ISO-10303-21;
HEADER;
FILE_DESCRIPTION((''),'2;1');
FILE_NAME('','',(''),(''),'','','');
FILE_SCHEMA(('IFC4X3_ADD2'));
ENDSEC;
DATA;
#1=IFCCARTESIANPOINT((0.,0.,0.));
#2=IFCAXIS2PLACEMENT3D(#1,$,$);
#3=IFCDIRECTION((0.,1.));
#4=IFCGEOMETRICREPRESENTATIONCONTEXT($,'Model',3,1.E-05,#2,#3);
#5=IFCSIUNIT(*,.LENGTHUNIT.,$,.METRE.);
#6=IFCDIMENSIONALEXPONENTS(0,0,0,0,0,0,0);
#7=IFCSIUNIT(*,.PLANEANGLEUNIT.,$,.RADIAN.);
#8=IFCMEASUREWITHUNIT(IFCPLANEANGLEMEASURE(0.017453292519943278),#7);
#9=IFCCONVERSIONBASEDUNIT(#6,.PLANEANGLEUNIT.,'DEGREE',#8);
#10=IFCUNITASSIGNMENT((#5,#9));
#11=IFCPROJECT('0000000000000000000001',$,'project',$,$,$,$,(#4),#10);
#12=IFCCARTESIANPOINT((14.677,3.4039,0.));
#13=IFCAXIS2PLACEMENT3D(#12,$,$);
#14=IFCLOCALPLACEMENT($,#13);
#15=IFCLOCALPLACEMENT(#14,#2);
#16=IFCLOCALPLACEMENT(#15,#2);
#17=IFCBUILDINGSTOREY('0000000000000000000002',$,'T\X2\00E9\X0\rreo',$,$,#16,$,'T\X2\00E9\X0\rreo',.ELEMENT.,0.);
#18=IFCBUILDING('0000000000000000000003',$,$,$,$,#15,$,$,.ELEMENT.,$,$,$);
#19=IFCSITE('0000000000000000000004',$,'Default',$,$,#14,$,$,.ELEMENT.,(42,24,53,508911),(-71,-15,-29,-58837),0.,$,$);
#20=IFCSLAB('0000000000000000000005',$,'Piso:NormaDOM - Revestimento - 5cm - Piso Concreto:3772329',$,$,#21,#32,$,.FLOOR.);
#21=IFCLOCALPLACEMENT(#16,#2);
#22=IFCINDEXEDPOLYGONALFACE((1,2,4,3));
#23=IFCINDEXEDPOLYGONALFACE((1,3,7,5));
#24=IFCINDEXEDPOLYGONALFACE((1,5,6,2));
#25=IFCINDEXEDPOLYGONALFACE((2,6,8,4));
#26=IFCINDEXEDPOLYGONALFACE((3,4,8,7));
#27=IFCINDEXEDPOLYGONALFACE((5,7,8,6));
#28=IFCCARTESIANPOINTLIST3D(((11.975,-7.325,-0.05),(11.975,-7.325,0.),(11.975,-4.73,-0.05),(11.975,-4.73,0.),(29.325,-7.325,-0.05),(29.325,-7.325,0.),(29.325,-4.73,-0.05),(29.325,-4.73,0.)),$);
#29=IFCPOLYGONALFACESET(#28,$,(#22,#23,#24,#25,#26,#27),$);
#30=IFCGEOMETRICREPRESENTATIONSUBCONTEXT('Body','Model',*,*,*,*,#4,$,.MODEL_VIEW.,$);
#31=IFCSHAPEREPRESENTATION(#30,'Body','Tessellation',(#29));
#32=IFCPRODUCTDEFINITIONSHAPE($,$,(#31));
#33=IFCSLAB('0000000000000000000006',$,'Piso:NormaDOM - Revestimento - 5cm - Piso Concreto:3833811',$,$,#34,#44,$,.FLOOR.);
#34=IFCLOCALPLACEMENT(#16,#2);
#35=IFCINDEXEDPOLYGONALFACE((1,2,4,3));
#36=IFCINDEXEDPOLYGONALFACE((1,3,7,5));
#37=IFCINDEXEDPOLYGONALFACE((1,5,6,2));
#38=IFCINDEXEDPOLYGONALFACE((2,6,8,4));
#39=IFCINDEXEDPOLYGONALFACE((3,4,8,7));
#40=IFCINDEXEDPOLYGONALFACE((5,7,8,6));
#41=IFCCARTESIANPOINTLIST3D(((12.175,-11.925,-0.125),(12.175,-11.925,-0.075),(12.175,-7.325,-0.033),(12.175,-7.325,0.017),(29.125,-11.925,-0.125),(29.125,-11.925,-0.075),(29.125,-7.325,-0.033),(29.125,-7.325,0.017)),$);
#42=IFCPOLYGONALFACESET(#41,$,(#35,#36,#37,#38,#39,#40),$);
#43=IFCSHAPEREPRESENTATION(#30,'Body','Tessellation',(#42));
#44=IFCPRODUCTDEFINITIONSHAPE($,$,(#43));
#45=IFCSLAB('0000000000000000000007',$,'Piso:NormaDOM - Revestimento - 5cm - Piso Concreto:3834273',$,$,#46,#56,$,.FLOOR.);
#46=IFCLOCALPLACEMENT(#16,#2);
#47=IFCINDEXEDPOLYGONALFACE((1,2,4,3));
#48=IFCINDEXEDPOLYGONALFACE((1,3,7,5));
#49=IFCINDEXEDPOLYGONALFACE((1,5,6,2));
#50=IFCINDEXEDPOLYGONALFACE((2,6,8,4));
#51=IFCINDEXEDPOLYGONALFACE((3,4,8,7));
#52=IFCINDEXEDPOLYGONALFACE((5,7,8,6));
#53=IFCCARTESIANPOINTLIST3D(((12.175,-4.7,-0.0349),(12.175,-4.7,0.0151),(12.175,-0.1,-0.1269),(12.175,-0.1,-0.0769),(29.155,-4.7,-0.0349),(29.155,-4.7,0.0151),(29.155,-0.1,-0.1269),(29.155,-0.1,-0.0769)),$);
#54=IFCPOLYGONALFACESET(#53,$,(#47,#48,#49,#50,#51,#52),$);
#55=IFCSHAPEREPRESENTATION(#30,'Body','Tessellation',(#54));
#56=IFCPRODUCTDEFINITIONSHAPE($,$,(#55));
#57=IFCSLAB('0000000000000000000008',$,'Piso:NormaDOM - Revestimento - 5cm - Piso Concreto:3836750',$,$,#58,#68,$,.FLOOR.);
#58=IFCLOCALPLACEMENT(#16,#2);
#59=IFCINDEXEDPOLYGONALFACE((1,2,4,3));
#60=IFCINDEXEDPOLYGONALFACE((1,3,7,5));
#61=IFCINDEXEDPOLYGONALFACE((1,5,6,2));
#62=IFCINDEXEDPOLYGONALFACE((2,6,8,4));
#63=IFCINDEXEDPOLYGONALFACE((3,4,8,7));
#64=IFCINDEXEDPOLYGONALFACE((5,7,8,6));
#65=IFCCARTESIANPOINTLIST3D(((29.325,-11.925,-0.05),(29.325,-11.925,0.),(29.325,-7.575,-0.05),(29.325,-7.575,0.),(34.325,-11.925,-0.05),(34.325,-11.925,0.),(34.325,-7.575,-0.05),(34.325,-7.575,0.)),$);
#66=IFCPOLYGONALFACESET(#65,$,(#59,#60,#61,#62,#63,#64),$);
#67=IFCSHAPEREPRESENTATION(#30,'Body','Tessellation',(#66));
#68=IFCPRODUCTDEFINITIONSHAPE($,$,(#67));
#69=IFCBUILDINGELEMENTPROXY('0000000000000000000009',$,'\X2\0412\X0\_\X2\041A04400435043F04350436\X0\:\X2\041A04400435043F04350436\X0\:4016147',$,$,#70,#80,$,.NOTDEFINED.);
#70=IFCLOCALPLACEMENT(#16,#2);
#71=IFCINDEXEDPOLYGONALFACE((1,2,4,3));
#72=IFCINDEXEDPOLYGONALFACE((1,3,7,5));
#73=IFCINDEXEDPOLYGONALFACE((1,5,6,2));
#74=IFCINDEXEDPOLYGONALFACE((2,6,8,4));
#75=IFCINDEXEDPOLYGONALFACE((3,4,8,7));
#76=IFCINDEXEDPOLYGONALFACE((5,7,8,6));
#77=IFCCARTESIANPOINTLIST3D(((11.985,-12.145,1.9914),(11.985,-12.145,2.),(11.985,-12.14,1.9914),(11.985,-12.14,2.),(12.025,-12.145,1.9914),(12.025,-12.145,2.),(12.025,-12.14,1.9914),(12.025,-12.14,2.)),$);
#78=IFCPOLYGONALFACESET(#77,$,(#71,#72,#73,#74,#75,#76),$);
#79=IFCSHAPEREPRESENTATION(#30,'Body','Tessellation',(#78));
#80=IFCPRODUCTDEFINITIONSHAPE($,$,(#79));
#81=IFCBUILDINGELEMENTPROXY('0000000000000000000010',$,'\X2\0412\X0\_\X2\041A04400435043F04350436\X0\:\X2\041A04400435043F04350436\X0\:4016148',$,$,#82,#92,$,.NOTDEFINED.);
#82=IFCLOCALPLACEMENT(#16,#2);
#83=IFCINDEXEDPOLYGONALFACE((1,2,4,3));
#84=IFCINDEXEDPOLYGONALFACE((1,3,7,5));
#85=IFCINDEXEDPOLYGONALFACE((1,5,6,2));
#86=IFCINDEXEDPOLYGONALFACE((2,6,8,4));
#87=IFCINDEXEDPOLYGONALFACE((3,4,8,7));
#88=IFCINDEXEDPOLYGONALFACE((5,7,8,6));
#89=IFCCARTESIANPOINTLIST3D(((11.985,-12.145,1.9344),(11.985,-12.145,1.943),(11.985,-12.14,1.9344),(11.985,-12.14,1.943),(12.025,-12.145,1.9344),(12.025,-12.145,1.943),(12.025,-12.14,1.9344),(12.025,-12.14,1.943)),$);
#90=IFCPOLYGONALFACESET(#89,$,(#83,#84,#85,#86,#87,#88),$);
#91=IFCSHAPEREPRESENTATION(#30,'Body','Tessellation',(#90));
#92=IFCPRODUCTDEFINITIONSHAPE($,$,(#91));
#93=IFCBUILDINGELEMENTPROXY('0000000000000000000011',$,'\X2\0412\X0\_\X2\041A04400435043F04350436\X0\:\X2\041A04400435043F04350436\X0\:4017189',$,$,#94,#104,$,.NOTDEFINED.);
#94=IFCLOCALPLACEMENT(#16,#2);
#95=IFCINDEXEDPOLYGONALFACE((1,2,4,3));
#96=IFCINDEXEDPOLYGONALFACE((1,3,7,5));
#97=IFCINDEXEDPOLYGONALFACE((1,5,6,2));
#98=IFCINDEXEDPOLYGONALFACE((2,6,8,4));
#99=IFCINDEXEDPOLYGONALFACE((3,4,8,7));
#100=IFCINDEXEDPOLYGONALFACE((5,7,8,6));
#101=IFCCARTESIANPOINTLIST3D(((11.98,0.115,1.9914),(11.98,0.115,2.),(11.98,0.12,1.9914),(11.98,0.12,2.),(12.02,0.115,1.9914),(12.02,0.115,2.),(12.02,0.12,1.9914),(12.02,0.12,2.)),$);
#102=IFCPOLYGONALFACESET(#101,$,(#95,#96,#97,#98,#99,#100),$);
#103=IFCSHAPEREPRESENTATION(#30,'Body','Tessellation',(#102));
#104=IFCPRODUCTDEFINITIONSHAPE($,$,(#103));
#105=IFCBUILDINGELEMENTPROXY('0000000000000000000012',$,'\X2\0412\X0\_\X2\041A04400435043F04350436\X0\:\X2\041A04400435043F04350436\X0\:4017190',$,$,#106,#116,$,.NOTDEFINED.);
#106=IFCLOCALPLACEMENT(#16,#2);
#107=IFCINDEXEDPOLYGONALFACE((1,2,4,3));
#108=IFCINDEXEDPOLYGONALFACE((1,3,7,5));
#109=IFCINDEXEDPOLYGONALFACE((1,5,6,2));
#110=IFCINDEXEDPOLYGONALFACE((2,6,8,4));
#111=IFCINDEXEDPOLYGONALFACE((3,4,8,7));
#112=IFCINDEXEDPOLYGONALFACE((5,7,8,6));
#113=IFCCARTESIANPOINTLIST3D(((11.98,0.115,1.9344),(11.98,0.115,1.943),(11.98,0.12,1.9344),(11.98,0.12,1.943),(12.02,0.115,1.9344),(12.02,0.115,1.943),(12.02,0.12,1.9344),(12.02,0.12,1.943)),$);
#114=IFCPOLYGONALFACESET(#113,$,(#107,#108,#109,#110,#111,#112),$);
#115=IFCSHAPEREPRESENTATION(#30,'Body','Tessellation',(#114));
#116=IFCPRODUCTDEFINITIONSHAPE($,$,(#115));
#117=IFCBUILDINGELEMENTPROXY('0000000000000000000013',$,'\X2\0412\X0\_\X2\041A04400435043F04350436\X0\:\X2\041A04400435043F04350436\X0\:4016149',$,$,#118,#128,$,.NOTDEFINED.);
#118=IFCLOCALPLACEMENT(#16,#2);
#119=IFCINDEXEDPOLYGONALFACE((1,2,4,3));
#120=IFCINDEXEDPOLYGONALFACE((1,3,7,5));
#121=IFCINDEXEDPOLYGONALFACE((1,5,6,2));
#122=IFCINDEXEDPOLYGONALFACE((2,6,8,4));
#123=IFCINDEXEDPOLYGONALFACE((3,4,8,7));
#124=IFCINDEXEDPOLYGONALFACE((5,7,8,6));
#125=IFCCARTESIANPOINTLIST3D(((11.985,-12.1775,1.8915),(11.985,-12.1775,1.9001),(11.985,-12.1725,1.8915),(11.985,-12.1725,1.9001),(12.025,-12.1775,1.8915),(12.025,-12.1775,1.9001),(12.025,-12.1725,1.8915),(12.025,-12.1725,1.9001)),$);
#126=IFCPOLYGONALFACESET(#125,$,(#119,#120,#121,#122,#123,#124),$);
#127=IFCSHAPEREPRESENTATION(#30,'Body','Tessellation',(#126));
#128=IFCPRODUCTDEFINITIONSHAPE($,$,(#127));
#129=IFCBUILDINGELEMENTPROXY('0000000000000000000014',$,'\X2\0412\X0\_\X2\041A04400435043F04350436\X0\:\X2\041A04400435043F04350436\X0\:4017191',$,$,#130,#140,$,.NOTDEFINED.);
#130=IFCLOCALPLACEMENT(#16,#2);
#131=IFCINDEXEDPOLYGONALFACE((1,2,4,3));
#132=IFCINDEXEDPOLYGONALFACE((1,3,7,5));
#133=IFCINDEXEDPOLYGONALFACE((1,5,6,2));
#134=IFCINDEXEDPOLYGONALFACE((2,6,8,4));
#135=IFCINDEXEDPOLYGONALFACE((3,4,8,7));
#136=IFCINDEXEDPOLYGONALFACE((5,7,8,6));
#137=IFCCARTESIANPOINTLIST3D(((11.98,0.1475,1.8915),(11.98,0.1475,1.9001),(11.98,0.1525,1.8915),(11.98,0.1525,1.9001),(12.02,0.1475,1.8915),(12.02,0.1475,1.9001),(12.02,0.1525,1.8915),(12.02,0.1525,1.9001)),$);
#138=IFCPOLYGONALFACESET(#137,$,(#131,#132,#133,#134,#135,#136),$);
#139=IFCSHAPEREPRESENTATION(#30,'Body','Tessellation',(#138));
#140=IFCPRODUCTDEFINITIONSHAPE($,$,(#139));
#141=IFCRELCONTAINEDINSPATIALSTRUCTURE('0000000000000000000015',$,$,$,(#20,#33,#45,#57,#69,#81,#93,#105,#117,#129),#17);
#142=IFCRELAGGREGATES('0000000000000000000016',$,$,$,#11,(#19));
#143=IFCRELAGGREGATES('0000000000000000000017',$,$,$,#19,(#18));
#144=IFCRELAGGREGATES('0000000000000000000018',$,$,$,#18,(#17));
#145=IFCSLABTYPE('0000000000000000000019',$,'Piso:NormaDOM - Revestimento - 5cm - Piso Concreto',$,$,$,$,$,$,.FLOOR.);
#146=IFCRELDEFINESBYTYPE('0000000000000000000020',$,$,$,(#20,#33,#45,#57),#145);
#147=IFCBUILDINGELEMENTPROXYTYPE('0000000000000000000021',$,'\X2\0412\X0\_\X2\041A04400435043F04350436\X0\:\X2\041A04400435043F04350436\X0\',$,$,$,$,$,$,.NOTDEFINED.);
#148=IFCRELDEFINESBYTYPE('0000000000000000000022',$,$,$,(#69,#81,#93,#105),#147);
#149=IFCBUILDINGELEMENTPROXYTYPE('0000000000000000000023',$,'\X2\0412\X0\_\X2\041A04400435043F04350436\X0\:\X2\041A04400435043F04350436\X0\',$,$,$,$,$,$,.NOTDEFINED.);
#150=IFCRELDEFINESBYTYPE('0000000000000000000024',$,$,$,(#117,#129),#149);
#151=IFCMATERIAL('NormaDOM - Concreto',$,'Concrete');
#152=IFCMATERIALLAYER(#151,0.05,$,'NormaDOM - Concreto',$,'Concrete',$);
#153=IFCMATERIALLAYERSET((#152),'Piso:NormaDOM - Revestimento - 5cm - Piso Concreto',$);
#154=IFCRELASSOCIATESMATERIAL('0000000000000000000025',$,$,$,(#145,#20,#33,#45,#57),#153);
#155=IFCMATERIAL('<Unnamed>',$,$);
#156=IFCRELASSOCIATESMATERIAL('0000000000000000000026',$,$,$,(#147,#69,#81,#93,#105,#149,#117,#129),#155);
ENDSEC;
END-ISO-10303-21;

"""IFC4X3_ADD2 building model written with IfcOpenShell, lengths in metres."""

from ifc_helpers import new_model, entity, si_unit, converted_unit, direction, frame, frame_2d, origin, origin_2d_with_axis, place, context, subcontext, project, spatial, rectangle, extrude, clip, halfspace, source, transform, mapped, material, layer, layer_set, layer_usage, type_object, type_shapes, element, save


model = new_model("IFC4X3_ADD2")

# Units and contexts
model_context = context("Model", 3, precision=1e-05, world=origin(), true_north=direction((0.0, 1.0)))
body_context = subcontext(model_context, "Body", "Model", "MODEL_VIEW")
ifc_project = project(units=[si_unit("LENGTHUNIT", "METRE"), converted_unit("PLANEANGLEUNIT", "DEGREE", entity("IfcPlaneAngleMeasure", 0.017453292519943278), si_unit("PLANEANGLEUNIT", "RADIAN"), dimensions=[0, 0, 0, 0, 0, 0, 0])], contexts=[model_context])

# Site, building, storey
site_placement = place(None, frame((14.677, 3.4039, 0.0)))
site = spatial("IfcSite", under=ifc_project, at=site_placement, Name="Default", CompositionType="ELEMENT", RefLatitude=(42, 24, 53, 508911), RefLongitude=(-71, -15, -29, -58837), RefElevation=0.0)
building_placement = place(site_placement, origin())
building = spatial("IfcBuilding", under=site, at=building_placement, CompositionType="ELEMENT")
storey_placement = place(building_placement, origin())
storey = spatial("IfcBuildingStorey", under=building, at=storey_placement, Name="Térreo", LongName="Térreo", CompositionType="ELEMENT", Elevation=0.0)

# Slabs
ifc_material_1 = material(Name="NormaDOM - Concreto", Category="Concrete")
ifc_layer_1 = layer(ifc_material_1, 0.05, Name="NormaDOM - Concreto", Category="Concrete")
ifc_layer_set_1 = layer_set([ifc_layer_1], Name="Piso:NormaDOM - Revestimento - 5cm - Piso Concreto")
ifc_layer_usage_1 = layer_usage(ifc_layer_set_1, "AXIS3", "POSITIVE", 0.0)
slab_type_1 = type_object("IfcSlabType", Name="Piso:NormaDOM - Revestimento - 5cm - Piso Concreto", PredefinedType="FLOOR", material=ifc_layer_set_1)
slab_1_placement = place(storey_placement, origin())
element("IfcSlab", 1, at=slab_1_placement, inside=storey, type_object=slab_type_1, material=ifc_layer_usage_1, Name="Piso:NormaDOM - Revestimento - 5cm - Piso Concreto:3772329", PredefinedType="FLOOR", context=body_context, shape_type="SweptSolid", body=[
    extrude(rectangle(XDim=2.595, YDim=17.35, at=frame_2d((0.0, 0.0), x_axis=(1.0, 0.0))), frame((20.65, -6.0275, 0.0), z_axis=(0.0, 0.0, -1.0), x_axis=(0.0, 1.0, 0.0)), (0.0, 0.0, 1.0), 0.05),
])
ifc_layer_usage_2 = layer_usage(ifc_layer_set_1, "AXIS3", "POSITIVE", 0.0)
slab_2_placement = place(storey_placement, origin())
element("IfcSlab", 2, at=slab_2_placement, inside=storey, type_object=slab_type_1, material=ifc_layer_usage_2, Name="Piso:NormaDOM - Revestimento - 5cm - Piso Concreto:3833811", PredefinedType="FLOOR", context=body_context, shape_type="Clipping", body=[
    clip(clip(extrude(rectangle(XDim=4.6009, YDim=16.95, at=frame_2d((0.0, 0.0), x_axis=(1.0, 0.0))), frame((20.65, -9.625, -0.029), z_axis=(0.0, 0.019996, -0.9998), x_axis=(0.0, 0.9998, 0.019996)), (-0.019996, 0.0, 0.9998), 0.05), halfspace(frame((20.8903, -8.1737, -0.05), z_axis=(0.0, 0.019996, -0.9998), x_axis=(0.0, -0.9998, -0.019996)), False)), halfspace(frame((20.8903, -8.1737, 0.0), z_axis=(0.0, -0.019996, 0.9998), x_axis=(0.0, 0.9998, 0.019996)), False)),
])
ifc_layer_usage_3 = layer_usage(ifc_layer_set_1, "AXIS3", "POSITIVE", 0.0)
slab_3_placement = place(storey_placement, origin())
element("IfcSlab", 3, at=slab_3_placement, inside=storey, type_object=slab_type_1, material=ifc_layer_usage_3, Name="Piso:NormaDOM - Revestimento - 5cm - Piso Concreto:3834273", PredefinedType="FLOOR", context=body_context, shape_type="Clipping", body=[
    clip(clip(extrude(rectangle(XDim=4.6009, YDim=16.98, at=origin_2d_with_axis()), frame((20.665, -2.4, -0.0309), z_axis=(0.0, -0.019996, -0.9998), x_axis=(0.0, 0.9998, -0.019996)), (0.019996, 0.0, 0.9998), 0.05), halfspace(frame((20.7124, -3.9462, -0.05), z_axis=(0.0, -0.019996, -0.9998), x_axis=(0.0, 0.9998, -0.019996)), False)), halfspace(frame((20.7124, -3.9462, 0.0), z_axis=(0.0, 0.019996, 0.9998), x_axis=(0.0, -0.9998, 0.019996)), False)),
])
ifc_layer_usage_4 = layer_usage(ifc_layer_set_1, "AXIS3", "POSITIVE", 0.0)
slab_4_placement = place(storey_placement, origin())
element("IfcSlab", 4, at=slab_4_placement, inside=storey, type_object=slab_type_1, material=ifc_layer_usage_4, Name="Piso:NormaDOM - Revestimento - 5cm - Piso Concreto:3836750", PredefinedType="FLOOR", context=body_context, shape_type="SweptSolid", body=[
    extrude(rectangle(XDim=4.35, YDim=5.0, at=frame_2d((0.0, 0.0), x_axis=(1.0, 0.0))), frame((31.825, -9.75, 0.0), z_axis=(0.0, 0.0, -1.0), x_axis=(0.0, 1.0, 0.0)), (0.0, 0.0, 1.0), 0.05),
])

# Building element proxies
ifc_material_2 = material(Name="<Unnamed>")
building_element_proxy_type_1 = type_object("IfcBuildingElementProxyType", Name="В_Крепеж:Крепеж", PredefinedType="NOTDEFINED", material=ifc_material_2)
shared_shape_1 = source(origin(), body_context, "Body", "SweptSolid", [
    extrude(rectangle(XDim=0.005, YDim=0.04, at=frame_2d((0.0, 0.0), x_axis=(1.0, 0.0))), frame((0.0, 0.0, -0.0043), z_axis=(0.0, 0.0, 1.0), x_axis=(0.0, 1.0, 0.0)), (0.0, 0.0, 1.0), 0.0086),
])
type_shapes(building_element_proxy_type_1, [shared_shape_1])
for number, where, z_axis, x_axis, name in (
    (5, (12.005, -12.1425, 1.9957), (0.0, 0.0, 1.0), (-1.0, 0.0, 0.0), "В_Крепеж:Крепеж:4016147"),
    (6, (12.005, -12.1425, 1.9387), (0.0, 0.0, 1.0), (-1.0, 0.0, 0.0), "В_Крепеж:Крепеж:4016148"),
):
    element("IfcBuildingElementProxy", number, at=place(storey_placement, frame(where, z_axis=z_axis, x_axis=x_axis)), inside=storey, type_object=building_element_proxy_type_1, material=ifc_material_2, Name=name, PredefinedType="NOTDEFINED", context=body_context, shape_type="MappedRepresentation", body=[
        mapped(shared_shape_1, transform((0.0, 0.0, 0.0), scale=1.0)),
    ])
for number, where, name in (
    (7, (12.0, 0.1175, 1.9957), "В_Крепеж:Крепеж:4017189"),
    (8, (12.0, 0.1175, 1.9387), "В_Крепеж:Крепеж:4017190"),
):
    element("IfcBuildingElementProxy", number, at=place(storey_placement, frame(where)), inside=storey, type_object=building_element_proxy_type_1, material=ifc_material_2, Name=name, PredefinedType="NOTDEFINED", context=body_context, shape_type="MappedRepresentation", body=[
        mapped(shared_shape_1, transform((0.0, 0.0, 0.0), scale=1.0)),
    ])
building_element_proxy_type_2 = type_object("IfcBuildingElementProxyType", Name="В_Крепеж:Крепеж", PredefinedType="NOTDEFINED", material=ifc_material_2)
shared_shape_2 = source(origin(), body_context, "Body", "SweptSolid", [
    extrude(rectangle(XDim=0.04, YDim=0.005, at=frame_2d((0.0, 0.0), x_axis=(1.0, 0.0))), frame((0.0, 0.0, -0.0043), z_axis=(0.0, 0.0, 1.0), x_axis=(-1.0, 0.0, 0.0)), (0.0, 0.0, 1.0), 0.0086),
])
type_shapes(building_element_proxy_type_2, [shared_shape_2])
proxy_1_placement = place(storey_placement, frame((12.005, -12.175, 1.8958), z_axis=(0.0, 0.0, 1.0), x_axis=(-1.0, 0.0, 0.0)))
element("IfcBuildingElementProxy", 9, at=proxy_1_placement, inside=storey, type_object=building_element_proxy_type_2, material=ifc_material_2, Name="В_Крепеж:Крепеж:4016149", PredefinedType="NOTDEFINED", context=body_context, shape_type="MappedRepresentation", body=[
    mapped(shared_shape_2, transform((0.0, 0.0, 0.0), scale=1.0)),
])
proxy_2_placement = place(storey_placement, frame((12.0, 0.15, 1.8958)))
element("IfcBuildingElementProxy", 10, at=proxy_2_placement, inside=storey, type_object=building_element_proxy_type_2, material=ifc_material_2, Name="В_Крепеж:Крепеж:4017191", PredefinedType="NOTDEFINED", context=body_context, shape_type="MappedRepresentation", body=[
    mapped(shared_shape_2, transform((0.0, 0.0, 0.0), scale=1.0)),
])

save(model, "model.ifc")
